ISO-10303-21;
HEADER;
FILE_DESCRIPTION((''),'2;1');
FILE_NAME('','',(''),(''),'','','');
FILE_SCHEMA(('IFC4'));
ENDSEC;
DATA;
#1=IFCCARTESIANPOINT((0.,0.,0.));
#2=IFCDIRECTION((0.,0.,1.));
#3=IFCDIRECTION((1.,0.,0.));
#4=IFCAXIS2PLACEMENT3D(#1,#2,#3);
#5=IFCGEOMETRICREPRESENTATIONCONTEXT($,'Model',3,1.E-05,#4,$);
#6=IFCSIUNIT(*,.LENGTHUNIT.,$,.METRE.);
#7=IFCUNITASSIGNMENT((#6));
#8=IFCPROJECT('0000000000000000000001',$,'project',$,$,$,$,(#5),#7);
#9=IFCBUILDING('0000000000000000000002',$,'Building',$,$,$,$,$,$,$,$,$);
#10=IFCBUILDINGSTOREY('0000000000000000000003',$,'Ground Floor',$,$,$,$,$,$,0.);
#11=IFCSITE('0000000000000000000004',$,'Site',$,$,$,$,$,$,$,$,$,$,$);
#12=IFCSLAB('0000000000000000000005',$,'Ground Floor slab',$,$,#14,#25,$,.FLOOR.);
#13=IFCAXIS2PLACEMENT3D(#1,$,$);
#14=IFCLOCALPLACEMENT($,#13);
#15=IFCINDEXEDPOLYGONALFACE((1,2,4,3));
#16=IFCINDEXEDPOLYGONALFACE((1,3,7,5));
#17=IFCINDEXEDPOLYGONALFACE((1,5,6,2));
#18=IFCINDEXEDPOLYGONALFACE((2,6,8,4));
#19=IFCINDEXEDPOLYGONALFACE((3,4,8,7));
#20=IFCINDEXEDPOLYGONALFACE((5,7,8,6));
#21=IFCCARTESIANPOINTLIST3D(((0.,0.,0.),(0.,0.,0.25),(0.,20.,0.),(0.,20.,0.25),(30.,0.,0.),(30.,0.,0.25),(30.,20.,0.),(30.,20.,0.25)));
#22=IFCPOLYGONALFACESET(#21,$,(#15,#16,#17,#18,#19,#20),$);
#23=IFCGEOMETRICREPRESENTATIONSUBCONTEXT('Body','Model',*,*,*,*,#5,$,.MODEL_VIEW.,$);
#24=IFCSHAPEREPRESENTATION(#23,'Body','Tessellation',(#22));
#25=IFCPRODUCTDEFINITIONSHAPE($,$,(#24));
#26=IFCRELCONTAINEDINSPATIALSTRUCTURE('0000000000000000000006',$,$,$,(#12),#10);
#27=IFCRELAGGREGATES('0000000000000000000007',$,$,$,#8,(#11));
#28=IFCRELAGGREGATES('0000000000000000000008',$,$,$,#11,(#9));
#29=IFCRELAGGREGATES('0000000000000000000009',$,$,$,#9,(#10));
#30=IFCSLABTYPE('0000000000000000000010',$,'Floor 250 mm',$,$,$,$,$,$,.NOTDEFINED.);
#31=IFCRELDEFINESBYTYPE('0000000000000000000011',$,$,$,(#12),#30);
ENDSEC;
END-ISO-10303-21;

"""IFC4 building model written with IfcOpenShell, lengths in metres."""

from ifc_helpers import new_model, si_unit, origin_with_axes, place, context, subcontext, project, spatial, indexed_curve, outline, extrude, type_object, element, save


model = new_model("IFC4")

# Units and contexts
model_context = context("Model", 3, precision=1e-05, world=origin_with_axes())
body_context = subcontext(model_context, "Body", "Model", "MODEL_VIEW")
ifc_project = project(units=[si_unit("LENGTHUNIT", "METRE")], contexts=[model_context])

# Site, building, storey
site = spatial("IfcSite", under=ifc_project, Name="Site")
building = spatial("IfcBuilding", under=site, Name="Building")
storey = spatial("IfcBuildingStorey", under=building, Name="Ground Floor", Elevation=0.0)

# Slab
slab_type = type_object("IfcSlabType", Name="Floor 250 mm", PredefinedType="NOTDEFINED")
slab_placement = place(None, origin_with_axes())
element("IfcSlab", 1, at=slab_placement, inside=storey, type_object=slab_type, Name="Ground Floor slab", PredefinedType="FLOOR", context=body_context, shape_type="SweptSolid", body=[
    extrude(outline(indexed_curve([(0.0, 0.0), (30.0, 0.0), (30.0, 20.0), (0.0, 20.0)])), None, (0.0, 0.0, 1.0), 0.25),
])

save(model, "model.ifc")
